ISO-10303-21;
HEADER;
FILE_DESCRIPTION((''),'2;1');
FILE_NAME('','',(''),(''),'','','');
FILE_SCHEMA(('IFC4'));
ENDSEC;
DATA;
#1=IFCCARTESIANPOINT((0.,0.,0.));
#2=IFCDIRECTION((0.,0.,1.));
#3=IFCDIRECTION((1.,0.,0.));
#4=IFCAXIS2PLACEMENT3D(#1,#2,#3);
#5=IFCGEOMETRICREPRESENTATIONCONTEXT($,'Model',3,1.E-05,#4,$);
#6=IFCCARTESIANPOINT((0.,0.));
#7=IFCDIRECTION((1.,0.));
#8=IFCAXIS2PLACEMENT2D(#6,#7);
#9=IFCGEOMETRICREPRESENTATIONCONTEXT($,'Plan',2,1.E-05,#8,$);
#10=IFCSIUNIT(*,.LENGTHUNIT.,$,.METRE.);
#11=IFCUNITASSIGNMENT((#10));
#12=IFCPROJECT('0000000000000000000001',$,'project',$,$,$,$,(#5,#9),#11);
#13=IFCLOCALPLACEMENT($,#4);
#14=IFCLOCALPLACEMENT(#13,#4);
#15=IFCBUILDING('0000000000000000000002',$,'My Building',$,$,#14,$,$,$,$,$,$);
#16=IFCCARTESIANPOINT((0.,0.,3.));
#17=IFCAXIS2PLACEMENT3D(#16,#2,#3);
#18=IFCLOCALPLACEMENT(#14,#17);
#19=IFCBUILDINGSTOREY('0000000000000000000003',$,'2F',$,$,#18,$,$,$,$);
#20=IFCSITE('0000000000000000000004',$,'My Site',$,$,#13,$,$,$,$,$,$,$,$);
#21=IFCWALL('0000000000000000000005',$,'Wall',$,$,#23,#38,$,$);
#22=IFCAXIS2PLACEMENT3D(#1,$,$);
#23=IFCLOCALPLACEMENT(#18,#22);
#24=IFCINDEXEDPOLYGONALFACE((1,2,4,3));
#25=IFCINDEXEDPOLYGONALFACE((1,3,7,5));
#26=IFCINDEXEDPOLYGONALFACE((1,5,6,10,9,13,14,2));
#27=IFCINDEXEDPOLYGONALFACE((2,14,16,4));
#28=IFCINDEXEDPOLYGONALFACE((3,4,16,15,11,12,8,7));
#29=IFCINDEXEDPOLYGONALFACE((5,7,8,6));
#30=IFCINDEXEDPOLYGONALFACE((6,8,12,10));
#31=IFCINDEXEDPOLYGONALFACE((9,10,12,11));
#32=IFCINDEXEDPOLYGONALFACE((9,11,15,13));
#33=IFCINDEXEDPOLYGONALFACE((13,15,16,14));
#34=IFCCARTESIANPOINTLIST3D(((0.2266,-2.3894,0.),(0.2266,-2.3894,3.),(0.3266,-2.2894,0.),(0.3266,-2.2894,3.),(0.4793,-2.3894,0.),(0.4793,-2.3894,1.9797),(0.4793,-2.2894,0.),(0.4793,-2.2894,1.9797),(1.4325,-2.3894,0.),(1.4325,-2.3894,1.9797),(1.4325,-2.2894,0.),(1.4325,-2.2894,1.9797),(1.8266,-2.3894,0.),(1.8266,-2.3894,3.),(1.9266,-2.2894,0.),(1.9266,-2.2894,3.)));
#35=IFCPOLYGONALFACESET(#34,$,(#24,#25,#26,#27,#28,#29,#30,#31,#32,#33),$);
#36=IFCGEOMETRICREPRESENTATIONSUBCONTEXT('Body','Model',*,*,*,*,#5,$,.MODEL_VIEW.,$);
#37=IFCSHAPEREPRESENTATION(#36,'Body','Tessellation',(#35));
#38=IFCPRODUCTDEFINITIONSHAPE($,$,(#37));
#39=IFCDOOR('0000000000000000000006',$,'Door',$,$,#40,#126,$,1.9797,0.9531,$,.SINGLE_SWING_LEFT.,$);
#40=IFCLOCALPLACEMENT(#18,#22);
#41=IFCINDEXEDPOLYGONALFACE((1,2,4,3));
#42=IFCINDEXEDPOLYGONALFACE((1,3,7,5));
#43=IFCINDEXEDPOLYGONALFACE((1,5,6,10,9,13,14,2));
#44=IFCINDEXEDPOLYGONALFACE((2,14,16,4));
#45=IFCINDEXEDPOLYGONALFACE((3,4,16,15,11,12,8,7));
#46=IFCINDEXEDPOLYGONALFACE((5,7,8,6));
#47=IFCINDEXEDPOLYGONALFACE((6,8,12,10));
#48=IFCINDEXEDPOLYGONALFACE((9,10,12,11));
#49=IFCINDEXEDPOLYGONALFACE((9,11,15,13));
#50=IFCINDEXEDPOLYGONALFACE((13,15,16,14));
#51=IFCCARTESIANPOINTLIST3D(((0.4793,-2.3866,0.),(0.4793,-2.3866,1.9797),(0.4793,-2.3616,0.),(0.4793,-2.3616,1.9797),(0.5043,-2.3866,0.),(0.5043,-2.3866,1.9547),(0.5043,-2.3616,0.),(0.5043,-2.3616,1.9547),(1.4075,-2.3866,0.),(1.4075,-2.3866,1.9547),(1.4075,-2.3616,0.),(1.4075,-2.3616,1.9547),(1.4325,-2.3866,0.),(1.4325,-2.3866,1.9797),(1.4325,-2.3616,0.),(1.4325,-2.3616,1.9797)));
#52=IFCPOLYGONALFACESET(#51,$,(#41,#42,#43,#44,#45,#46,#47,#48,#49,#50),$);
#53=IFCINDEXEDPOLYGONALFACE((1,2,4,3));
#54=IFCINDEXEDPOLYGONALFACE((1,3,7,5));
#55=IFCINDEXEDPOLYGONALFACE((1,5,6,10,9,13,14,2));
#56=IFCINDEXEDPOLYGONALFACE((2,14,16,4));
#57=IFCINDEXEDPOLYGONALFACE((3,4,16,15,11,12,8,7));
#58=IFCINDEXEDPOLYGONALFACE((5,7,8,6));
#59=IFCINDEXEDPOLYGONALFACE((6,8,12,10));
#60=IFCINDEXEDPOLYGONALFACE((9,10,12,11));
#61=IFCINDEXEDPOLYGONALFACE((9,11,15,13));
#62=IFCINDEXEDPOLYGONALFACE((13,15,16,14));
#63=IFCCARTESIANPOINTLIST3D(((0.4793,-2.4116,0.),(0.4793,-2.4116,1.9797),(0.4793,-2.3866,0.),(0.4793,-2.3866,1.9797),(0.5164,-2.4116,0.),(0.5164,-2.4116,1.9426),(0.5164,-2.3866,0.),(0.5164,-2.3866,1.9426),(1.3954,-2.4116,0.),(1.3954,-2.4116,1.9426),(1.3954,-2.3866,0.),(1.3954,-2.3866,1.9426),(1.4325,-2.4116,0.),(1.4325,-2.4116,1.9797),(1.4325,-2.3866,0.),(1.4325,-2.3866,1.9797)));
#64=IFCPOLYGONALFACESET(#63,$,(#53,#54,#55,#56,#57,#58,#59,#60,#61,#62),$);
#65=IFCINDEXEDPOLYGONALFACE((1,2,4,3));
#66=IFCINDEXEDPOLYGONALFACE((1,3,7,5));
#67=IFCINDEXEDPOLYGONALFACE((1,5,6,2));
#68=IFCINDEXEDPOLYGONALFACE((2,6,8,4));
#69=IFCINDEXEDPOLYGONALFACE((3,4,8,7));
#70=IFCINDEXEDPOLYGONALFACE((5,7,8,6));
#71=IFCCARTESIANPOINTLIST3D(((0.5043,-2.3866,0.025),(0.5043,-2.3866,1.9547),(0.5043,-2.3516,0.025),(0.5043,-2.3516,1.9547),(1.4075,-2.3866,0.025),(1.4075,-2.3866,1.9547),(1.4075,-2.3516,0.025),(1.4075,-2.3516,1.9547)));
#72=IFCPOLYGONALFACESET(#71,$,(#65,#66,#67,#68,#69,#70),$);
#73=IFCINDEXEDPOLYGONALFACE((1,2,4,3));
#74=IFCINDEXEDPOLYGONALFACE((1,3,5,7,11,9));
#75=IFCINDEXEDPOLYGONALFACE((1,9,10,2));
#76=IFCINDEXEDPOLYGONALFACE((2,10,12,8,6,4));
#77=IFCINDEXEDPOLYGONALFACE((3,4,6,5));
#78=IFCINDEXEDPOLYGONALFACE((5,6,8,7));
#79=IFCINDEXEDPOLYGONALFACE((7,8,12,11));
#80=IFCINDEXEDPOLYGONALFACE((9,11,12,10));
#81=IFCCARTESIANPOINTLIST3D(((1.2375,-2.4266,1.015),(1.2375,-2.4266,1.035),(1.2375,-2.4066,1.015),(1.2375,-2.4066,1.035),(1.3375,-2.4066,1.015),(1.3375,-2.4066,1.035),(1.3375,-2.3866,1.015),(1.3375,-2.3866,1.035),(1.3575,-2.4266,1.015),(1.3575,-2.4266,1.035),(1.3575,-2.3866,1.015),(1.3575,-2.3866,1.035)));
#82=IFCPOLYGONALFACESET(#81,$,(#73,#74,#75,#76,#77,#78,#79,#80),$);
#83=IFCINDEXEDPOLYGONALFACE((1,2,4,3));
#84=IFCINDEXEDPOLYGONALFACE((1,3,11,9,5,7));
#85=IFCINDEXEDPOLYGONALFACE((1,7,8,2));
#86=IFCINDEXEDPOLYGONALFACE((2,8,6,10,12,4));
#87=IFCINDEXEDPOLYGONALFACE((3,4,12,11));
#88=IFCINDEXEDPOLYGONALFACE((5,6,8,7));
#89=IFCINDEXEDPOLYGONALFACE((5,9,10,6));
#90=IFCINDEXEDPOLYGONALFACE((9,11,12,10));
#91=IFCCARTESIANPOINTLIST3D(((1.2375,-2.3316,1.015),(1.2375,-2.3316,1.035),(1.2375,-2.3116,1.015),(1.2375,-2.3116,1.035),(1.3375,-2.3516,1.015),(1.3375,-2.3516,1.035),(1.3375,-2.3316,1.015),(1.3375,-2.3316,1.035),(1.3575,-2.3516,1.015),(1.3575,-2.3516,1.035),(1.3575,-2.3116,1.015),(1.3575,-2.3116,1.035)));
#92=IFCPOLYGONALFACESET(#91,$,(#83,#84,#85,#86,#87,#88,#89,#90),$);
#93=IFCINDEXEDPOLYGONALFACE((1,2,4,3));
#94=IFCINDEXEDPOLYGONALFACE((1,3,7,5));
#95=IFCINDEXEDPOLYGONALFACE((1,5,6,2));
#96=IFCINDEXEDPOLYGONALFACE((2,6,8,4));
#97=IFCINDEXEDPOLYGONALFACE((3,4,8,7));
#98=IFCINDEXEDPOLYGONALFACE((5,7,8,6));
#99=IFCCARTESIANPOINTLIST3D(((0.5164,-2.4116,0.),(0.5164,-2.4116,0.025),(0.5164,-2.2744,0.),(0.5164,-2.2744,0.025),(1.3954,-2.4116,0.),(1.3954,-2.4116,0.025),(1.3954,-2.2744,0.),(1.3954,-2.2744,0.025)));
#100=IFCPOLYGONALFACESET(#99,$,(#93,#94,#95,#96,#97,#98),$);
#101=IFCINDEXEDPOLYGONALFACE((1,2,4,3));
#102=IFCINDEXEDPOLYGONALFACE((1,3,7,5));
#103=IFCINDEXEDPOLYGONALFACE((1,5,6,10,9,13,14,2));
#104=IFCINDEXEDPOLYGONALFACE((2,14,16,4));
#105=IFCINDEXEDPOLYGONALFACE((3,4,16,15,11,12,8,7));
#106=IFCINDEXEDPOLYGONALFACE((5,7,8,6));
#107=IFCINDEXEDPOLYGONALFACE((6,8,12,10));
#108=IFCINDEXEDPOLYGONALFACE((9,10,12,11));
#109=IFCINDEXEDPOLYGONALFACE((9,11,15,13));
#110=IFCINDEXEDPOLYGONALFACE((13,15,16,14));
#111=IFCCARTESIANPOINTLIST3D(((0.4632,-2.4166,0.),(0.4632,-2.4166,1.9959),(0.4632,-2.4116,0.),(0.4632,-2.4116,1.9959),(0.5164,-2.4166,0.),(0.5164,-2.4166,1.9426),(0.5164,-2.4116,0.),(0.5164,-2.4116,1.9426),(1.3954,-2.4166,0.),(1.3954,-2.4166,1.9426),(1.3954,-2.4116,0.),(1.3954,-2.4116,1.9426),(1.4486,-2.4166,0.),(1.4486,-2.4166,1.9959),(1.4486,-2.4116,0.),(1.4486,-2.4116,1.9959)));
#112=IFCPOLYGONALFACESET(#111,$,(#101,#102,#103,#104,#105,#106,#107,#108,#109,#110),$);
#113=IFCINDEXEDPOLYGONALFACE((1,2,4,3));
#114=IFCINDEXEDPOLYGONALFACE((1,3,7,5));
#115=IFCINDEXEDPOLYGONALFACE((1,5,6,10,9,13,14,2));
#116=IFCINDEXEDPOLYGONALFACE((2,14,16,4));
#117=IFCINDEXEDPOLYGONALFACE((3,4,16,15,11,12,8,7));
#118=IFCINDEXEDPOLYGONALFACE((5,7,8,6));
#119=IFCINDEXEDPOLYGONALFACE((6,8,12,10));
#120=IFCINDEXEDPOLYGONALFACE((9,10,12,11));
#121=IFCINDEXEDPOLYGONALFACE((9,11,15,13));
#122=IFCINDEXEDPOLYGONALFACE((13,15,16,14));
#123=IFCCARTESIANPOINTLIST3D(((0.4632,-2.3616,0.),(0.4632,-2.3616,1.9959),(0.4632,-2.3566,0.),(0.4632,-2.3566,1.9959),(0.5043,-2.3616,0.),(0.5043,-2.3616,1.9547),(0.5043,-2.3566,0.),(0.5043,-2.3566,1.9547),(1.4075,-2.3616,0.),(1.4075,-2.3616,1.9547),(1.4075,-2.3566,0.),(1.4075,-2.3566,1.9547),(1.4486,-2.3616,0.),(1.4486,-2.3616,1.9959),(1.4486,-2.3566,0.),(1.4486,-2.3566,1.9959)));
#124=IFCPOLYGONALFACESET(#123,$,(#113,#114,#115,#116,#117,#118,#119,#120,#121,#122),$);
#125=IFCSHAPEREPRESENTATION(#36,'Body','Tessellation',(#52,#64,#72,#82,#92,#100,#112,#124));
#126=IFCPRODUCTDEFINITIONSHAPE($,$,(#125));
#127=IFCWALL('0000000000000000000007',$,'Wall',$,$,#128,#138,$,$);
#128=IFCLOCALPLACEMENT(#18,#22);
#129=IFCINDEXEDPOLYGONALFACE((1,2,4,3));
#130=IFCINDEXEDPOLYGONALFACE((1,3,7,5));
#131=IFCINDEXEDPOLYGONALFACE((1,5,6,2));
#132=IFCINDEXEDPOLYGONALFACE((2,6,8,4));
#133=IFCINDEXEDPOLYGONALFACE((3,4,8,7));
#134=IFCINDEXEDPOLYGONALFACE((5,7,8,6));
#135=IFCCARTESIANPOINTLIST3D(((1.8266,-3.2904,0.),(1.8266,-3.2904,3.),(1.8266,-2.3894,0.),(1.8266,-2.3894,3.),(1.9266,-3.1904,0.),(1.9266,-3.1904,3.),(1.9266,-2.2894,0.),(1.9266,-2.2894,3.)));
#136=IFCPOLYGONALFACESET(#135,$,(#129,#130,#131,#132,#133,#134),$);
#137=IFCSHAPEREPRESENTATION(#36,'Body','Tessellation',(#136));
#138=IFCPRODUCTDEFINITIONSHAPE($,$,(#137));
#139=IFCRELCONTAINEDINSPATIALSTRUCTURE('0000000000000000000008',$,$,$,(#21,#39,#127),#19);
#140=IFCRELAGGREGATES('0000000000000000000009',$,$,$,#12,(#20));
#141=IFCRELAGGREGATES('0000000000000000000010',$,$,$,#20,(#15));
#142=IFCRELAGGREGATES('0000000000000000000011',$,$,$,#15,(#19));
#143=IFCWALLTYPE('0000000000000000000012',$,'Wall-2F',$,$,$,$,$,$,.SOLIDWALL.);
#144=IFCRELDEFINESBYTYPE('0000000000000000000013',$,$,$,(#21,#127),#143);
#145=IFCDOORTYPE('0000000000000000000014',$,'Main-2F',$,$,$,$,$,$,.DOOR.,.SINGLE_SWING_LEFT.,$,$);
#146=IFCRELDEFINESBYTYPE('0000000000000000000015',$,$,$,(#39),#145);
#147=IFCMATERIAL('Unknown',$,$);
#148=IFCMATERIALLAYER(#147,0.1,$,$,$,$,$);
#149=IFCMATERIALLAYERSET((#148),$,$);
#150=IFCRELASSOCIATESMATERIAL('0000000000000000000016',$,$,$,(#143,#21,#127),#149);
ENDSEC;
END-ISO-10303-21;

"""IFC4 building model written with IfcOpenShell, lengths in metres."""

from ifc_helpers import new_model, entity, si_unit, frame, origin_with_axes, origin_2d_with_axis, place, context, subcontext, project, spatial, line, indexed_curve, outline, extrude, shape, source, transform, mapped, material, layer, layer_set, layer_usage, type_object, type_shapes, element, fill, save


model = new_model("IFC4")

# Units and contexts
model_context = context("Model", 3, precision=1e-05, world=origin_with_axes())
plan_context = context("Plan", 2, precision=1e-05, world=origin_2d_with_axis())
body_context_1 = subcontext(model_context, "Body", "Model", "MODEL_VIEW")
body_context_2 = subcontext(plan_context, "Body", "Plan", "PLAN_VIEW")
ifc_project = project(units=[si_unit("LENGTHUNIT", "METRE")], contexts=[model_context, plan_context])

# Site, building, storey
site_placement = place(None, origin_with_axes())
site = spatial("IfcSite", under=ifc_project, at=site_placement, Name="My Site")
building_placement = place(site_placement, origin_with_axes())
building = spatial("IfcBuilding", under=site, at=building_placement, Name="My Building")
storey_placement = place(building_placement, frame((0.0, 0.0, 3.0), z_axis=(0.0, 0.0, 1.0), x_axis=(1.0, 0.0, 0.0)))
storey = spatial("IfcBuildingStorey", under=building, at=storey_placement, Name="2F")

# Shared definitions
ifc_material = material(Name="Unknown")

# Shared definitions
ifc_layer_1 = layer(ifc_material, 0.1)
ifc_layer_set_1 = layer_set([ifc_layer_1])
wall_type = type_object("IfcWallType", Name="Wall-2F", PredefinedType="SOLIDWALL", material=ifc_layer_set_1)

# Wall, opening, door
ifc_layer_usage_1 = layer_usage(ifc_layer_set_1, "AXIS2", "POSITIVE", 0.0)
wall_1_placement = place(storey_placement, frame((0.2266, -2.3894, 0.0), z_axis=(0.0, 0.0, 1.0), x_axis=(1.0, 0.0, 0.0)))
wall_1 = element("IfcWall", 1, at=wall_1_placement, inside=storey, type_object=wall_type, material=ifc_layer_usage_1, Name="Wall", context=body_context_1, shape_type="SweptSolid", body=[
    extrude(outline(indexed_curve([(0.0, 0.0), (0.1, 0.1), (1.7, 0.1), (1.6, 0.0)], segments=[line(1, 2, 3, 4, 1)])), origin_with_axes(), (0.0, 0.0, 1.0), 3.0),
])
shared_shape_1 = source(origin_with_axes(), body_context_1, "Body", "SweptSolid", [
    extrude(outline(indexed_curve([(0.0, 0.0), (0.9531, 0.0), (0.9531, 1.9797), (0.0, 1.9797)], segments=[line(1, 2, 3, 4, 1)])), frame((0.0, -0.6, 0.0), z_axis=(0.0, -1.0, 0.0), x_axis=(1.0, 0.0, 0.0)), (0.0, 0.0, -1.0), 1.2),
])
opening_1_placement = place(wall_1_placement, frame((0.2527, -0.0222, 0.0), z_axis=(0.0, 0.0, 1.0), x_axis=(1.0, 0.0, 0.0)))
opening_1 = element("IfcOpeningElement", 2, at=opening_1_placement, cuts=wall_1, PredefinedType="OPENING", context=body_context_1, shape_type="MappedRepresentation", body=[
    mapped(shared_shape_1, transform((0.0, 0.0, 0.0), x_axis=(1.0, 0.0, 0.0), y_axis=(0.0, 1.0, 0.0), z_axis=(0.0, 0.0, 1.0), scale=1.0)),
])
door_type_1 = type_object("IfcDoorType", Name="Main-2F", OperationType="SINGLE_SWING_LEFT", PredefinedType="DOOR")
shared_shape_2 = source(origin_with_axes(), body_context_1, "Body", "SweptSolid", [
    extrude(outline(indexed_curve([(0.0, 0.0), (0.0, 1.9797), (0.9531, 1.9797), (0.9531, 0.0), (0.9281, 0.0), (0.9281, 1.9547), (0.025, 1.9547), (0.025, 0.0)], segments=[line(1, 2, 3, 4, 5, 6, 7, 8, 1)])), frame((0.0, 0.025, 0.0), z_axis=(0.0, -1.0, 0.0), x_axis=(1.0, 0.0, 0.0)), (0.0, 0.0, -1.0), 0.025),
    extrude(outline(indexed_curve([(0.0, 0.0), (0.0, 1.9797), (0.9531, 1.9797), (0.9531, 0.0), (0.9161, 0.0), (0.9161, 1.9426), (0.0371, 1.9426), (0.0371, 0.0)], segments=[line(1, 2, 3, 4, 5, 6, 7, 8, 1)])), frame((0.0, 0.0, 0.0), z_axis=(0.0, -1.0, 0.0), x_axis=(1.0, 0.0, 0.0)), (0.0, 0.0, -1.0), 0.025),
    extrude(outline(indexed_curve([(0.0, 0.0), (0.9031, 0.0), (0.9031, 0.035), (0.0, 0.035)], segments=[line(1, 2, 3, 4, 1)])), frame((0.025, 0.025, 0.025), z_axis=(0.0, 0.0, 1.0), x_axis=(1.0, 0.0, 0.0)), (0.0, 0.0, 1.0), 1.9297),
    extrude(outline(indexed_curve([(0.0, 0.0), (0.0, -0.04), (-0.12, -0.04), (-0.12, -0.02), (-0.02, -0.02), (-0.02, 0.0)], segments=[line(1, 2, 3, 4, 5, 6, 1)])), frame((0.8781, 0.025, 1.015), z_axis=(0.0, 0.0, 1.0), x_axis=(1.0, 0.0, 0.0)), (0.0, 0.0, 1.0), 0.02),
    extrude(outline(indexed_curve([(0.0, 0.0), (0.0, 0.04), (-0.12, 0.04), (-0.12, 0.02), (-0.02, 0.02), (-0.02, 0.0)], segments=[line(1, 2, 3, 4, 5, 6, 1)])), frame((0.8781, 0.06, 1.015), z_axis=(0.0, 0.0, 1.0), x_axis=(1.0, 0.0, 0.0)), (0.0, 0.0, 1.0), 0.02),
    extrude(outline(indexed_curve([(0.0, 0.0), (0.879, 0.0), (0.879, 0.1372), (0.0, 0.1372)], segments=[line(1, 2, 3, 4, 1)])), frame((0.0371, 0.0, 0.0), z_axis=(0.0, 0.0, 1.0), x_axis=(1.0, 0.0, 0.0)), (0.0, 0.0, 1.0), 0.025),
    extrude(outline(indexed_curve([(0.0, 0.0), (0.0, 1.9959), (0.9855, 1.9959), (0.9855, 0.0), (0.9322, 0.0), (0.9322, 1.9426), (0.0532, 1.9426), (0.0532, 0.0)], segments=[line(1, 2, 3, 4, 5, 6, 7, 8, 1)])), frame((-0.0162, -0.005, 0.0), z_axis=(0.0, -1.0, 0.0), x_axis=(1.0, 0.0, 0.0)), (0.0, 0.0, -1.0), 0.005),
    extrude(outline(indexed_curve([(0.0, 0.0), (0.0, 1.9959), (0.9855, 1.9959), (0.9855, 0.0), (0.9443, 0.0), (0.9443, 1.9547), (0.0412, 1.9547), (0.0412, 0.0)], segments=[line(1, 2, 3, 4, 5, 6, 7, 8, 1)])), frame((-0.0162, 0.05, 0.0), z_axis=(0.0, -1.0, 0.0), x_axis=(1.0, 0.0, 0.0)), (0.0, 0.0, -1.0), 0.005),
])
shared_shape_3 = source(origin_with_axes(), body_context_2, "Body", "Curve2D", [
    entity("IfcIndexedPolyCurve", entity("IfcCartesianPointList2D", [[0.0, 0.0], [0.0, 0.05], [0.025, 0.05], [0.025, 0.025], [0.0371, 0.025], [0.0371, 0.0]]), [entity("IfcLineIndex", [1, 2, 3, 4, 5, 6, 1])]),
    entity("IfcIndexedPolyCurve", entity("IfcCartesianPointList2D", [[0.9531, 0.0], [0.9531, 0.05], [0.9281, 0.05], [0.9281, 0.025], [0.9161, 0.025], [0.9161, 0.0]]), [entity("IfcLineIndex", [1, 2, 3, 4, 5, 6, 1])]),
    entity("IfcTrimmedCurve", entity("IfcEllipse", entity("IfcAxis2Placement2D", entity("IfcCartesianPoint", [0.06, 0.05]), entity("IfcDirection", [1.0, 0.0])), 0.8681, 0.9031), [entity("IfcCartesianPoint", [0.9281, 0.05])], [entity("IfcCartesianPoint", [0.06, 0.9531])], True, "CARTESIAN"),
    entity("IfcIndexedPolyCurve", entity("IfcCartesianPointList2D", [[0.025, 0.05], [0.06, 0.05], [0.06, 0.9531], [0.025, 0.9531]]), [entity("IfcLineIndex", [1, 2, 3, 4, 1])]),
])
type_shapes(door_type_1, [shared_shape_2, shared_shape_3])
door_1_placement = place(opening_1_placement, frame((0.0, 0.0, 0.0), z_axis=(0.0, 0.0, 1.0), x_axis=(1.0, 0.0, 0.0)))
door_1 = element("IfcDoor", 3, at=door_1_placement, inside=storey, type_object=door_type_1, Name="Door", OperationType="SINGLE_SWING_LEFT", OverallHeight=1.9797, OverallWidth=0.9531, shapes=[
    shape(body_context_1, "Body", "MappedRepresentation", [mapped(shared_shape_2, transform((0.0, 0.0, 0.0), x_axis=(1.0, 0.0, 0.0), y_axis=(0.0, 1.0, 0.0), z_axis=(0.0, 0.0, 1.0), scale=1.0))]),
    shape(body_context_2, "Body", "MappedRepresentation", [mapped(shared_shape_3, transform((0.0, 0.0, 0.0), x_axis=(1.0, 0.0, 0.0), y_axis=(0.0, 1.0, 0.0), z_axis=(0.0, 0.0, 1.0), scale=1.0))]),
])
fill(opening_1, door_1)

# Wall
ifc_layer_usage_2 = layer_usage(ifc_layer_set_1, "AXIS2", "POSITIVE", 0.0)
wall_2_placement = place(storey_placement, frame((1.8266, -2.3894, 0.0), z_axis=(0.0, 0.0, 1.0), x_axis=(0.0, -1.0, 0.0)))
element("IfcWall", 4, at=wall_2_placement, inside=storey, type_object=wall_type, material=ifc_layer_usage_2, Name="Wall", context=body_context_1, shape_type="SweptSolid", body=[
    extrude(outline(indexed_curve([(0.0, 0.0), (-0.1, 0.1), (0.801, 0.1), (0.901, 0.0)], segments=[line(1, 2, 3, 4, 1)])), origin_with_axes(), (0.0, 0.0, 1.0), 3.0),
])

save(model, "model.ifc")
